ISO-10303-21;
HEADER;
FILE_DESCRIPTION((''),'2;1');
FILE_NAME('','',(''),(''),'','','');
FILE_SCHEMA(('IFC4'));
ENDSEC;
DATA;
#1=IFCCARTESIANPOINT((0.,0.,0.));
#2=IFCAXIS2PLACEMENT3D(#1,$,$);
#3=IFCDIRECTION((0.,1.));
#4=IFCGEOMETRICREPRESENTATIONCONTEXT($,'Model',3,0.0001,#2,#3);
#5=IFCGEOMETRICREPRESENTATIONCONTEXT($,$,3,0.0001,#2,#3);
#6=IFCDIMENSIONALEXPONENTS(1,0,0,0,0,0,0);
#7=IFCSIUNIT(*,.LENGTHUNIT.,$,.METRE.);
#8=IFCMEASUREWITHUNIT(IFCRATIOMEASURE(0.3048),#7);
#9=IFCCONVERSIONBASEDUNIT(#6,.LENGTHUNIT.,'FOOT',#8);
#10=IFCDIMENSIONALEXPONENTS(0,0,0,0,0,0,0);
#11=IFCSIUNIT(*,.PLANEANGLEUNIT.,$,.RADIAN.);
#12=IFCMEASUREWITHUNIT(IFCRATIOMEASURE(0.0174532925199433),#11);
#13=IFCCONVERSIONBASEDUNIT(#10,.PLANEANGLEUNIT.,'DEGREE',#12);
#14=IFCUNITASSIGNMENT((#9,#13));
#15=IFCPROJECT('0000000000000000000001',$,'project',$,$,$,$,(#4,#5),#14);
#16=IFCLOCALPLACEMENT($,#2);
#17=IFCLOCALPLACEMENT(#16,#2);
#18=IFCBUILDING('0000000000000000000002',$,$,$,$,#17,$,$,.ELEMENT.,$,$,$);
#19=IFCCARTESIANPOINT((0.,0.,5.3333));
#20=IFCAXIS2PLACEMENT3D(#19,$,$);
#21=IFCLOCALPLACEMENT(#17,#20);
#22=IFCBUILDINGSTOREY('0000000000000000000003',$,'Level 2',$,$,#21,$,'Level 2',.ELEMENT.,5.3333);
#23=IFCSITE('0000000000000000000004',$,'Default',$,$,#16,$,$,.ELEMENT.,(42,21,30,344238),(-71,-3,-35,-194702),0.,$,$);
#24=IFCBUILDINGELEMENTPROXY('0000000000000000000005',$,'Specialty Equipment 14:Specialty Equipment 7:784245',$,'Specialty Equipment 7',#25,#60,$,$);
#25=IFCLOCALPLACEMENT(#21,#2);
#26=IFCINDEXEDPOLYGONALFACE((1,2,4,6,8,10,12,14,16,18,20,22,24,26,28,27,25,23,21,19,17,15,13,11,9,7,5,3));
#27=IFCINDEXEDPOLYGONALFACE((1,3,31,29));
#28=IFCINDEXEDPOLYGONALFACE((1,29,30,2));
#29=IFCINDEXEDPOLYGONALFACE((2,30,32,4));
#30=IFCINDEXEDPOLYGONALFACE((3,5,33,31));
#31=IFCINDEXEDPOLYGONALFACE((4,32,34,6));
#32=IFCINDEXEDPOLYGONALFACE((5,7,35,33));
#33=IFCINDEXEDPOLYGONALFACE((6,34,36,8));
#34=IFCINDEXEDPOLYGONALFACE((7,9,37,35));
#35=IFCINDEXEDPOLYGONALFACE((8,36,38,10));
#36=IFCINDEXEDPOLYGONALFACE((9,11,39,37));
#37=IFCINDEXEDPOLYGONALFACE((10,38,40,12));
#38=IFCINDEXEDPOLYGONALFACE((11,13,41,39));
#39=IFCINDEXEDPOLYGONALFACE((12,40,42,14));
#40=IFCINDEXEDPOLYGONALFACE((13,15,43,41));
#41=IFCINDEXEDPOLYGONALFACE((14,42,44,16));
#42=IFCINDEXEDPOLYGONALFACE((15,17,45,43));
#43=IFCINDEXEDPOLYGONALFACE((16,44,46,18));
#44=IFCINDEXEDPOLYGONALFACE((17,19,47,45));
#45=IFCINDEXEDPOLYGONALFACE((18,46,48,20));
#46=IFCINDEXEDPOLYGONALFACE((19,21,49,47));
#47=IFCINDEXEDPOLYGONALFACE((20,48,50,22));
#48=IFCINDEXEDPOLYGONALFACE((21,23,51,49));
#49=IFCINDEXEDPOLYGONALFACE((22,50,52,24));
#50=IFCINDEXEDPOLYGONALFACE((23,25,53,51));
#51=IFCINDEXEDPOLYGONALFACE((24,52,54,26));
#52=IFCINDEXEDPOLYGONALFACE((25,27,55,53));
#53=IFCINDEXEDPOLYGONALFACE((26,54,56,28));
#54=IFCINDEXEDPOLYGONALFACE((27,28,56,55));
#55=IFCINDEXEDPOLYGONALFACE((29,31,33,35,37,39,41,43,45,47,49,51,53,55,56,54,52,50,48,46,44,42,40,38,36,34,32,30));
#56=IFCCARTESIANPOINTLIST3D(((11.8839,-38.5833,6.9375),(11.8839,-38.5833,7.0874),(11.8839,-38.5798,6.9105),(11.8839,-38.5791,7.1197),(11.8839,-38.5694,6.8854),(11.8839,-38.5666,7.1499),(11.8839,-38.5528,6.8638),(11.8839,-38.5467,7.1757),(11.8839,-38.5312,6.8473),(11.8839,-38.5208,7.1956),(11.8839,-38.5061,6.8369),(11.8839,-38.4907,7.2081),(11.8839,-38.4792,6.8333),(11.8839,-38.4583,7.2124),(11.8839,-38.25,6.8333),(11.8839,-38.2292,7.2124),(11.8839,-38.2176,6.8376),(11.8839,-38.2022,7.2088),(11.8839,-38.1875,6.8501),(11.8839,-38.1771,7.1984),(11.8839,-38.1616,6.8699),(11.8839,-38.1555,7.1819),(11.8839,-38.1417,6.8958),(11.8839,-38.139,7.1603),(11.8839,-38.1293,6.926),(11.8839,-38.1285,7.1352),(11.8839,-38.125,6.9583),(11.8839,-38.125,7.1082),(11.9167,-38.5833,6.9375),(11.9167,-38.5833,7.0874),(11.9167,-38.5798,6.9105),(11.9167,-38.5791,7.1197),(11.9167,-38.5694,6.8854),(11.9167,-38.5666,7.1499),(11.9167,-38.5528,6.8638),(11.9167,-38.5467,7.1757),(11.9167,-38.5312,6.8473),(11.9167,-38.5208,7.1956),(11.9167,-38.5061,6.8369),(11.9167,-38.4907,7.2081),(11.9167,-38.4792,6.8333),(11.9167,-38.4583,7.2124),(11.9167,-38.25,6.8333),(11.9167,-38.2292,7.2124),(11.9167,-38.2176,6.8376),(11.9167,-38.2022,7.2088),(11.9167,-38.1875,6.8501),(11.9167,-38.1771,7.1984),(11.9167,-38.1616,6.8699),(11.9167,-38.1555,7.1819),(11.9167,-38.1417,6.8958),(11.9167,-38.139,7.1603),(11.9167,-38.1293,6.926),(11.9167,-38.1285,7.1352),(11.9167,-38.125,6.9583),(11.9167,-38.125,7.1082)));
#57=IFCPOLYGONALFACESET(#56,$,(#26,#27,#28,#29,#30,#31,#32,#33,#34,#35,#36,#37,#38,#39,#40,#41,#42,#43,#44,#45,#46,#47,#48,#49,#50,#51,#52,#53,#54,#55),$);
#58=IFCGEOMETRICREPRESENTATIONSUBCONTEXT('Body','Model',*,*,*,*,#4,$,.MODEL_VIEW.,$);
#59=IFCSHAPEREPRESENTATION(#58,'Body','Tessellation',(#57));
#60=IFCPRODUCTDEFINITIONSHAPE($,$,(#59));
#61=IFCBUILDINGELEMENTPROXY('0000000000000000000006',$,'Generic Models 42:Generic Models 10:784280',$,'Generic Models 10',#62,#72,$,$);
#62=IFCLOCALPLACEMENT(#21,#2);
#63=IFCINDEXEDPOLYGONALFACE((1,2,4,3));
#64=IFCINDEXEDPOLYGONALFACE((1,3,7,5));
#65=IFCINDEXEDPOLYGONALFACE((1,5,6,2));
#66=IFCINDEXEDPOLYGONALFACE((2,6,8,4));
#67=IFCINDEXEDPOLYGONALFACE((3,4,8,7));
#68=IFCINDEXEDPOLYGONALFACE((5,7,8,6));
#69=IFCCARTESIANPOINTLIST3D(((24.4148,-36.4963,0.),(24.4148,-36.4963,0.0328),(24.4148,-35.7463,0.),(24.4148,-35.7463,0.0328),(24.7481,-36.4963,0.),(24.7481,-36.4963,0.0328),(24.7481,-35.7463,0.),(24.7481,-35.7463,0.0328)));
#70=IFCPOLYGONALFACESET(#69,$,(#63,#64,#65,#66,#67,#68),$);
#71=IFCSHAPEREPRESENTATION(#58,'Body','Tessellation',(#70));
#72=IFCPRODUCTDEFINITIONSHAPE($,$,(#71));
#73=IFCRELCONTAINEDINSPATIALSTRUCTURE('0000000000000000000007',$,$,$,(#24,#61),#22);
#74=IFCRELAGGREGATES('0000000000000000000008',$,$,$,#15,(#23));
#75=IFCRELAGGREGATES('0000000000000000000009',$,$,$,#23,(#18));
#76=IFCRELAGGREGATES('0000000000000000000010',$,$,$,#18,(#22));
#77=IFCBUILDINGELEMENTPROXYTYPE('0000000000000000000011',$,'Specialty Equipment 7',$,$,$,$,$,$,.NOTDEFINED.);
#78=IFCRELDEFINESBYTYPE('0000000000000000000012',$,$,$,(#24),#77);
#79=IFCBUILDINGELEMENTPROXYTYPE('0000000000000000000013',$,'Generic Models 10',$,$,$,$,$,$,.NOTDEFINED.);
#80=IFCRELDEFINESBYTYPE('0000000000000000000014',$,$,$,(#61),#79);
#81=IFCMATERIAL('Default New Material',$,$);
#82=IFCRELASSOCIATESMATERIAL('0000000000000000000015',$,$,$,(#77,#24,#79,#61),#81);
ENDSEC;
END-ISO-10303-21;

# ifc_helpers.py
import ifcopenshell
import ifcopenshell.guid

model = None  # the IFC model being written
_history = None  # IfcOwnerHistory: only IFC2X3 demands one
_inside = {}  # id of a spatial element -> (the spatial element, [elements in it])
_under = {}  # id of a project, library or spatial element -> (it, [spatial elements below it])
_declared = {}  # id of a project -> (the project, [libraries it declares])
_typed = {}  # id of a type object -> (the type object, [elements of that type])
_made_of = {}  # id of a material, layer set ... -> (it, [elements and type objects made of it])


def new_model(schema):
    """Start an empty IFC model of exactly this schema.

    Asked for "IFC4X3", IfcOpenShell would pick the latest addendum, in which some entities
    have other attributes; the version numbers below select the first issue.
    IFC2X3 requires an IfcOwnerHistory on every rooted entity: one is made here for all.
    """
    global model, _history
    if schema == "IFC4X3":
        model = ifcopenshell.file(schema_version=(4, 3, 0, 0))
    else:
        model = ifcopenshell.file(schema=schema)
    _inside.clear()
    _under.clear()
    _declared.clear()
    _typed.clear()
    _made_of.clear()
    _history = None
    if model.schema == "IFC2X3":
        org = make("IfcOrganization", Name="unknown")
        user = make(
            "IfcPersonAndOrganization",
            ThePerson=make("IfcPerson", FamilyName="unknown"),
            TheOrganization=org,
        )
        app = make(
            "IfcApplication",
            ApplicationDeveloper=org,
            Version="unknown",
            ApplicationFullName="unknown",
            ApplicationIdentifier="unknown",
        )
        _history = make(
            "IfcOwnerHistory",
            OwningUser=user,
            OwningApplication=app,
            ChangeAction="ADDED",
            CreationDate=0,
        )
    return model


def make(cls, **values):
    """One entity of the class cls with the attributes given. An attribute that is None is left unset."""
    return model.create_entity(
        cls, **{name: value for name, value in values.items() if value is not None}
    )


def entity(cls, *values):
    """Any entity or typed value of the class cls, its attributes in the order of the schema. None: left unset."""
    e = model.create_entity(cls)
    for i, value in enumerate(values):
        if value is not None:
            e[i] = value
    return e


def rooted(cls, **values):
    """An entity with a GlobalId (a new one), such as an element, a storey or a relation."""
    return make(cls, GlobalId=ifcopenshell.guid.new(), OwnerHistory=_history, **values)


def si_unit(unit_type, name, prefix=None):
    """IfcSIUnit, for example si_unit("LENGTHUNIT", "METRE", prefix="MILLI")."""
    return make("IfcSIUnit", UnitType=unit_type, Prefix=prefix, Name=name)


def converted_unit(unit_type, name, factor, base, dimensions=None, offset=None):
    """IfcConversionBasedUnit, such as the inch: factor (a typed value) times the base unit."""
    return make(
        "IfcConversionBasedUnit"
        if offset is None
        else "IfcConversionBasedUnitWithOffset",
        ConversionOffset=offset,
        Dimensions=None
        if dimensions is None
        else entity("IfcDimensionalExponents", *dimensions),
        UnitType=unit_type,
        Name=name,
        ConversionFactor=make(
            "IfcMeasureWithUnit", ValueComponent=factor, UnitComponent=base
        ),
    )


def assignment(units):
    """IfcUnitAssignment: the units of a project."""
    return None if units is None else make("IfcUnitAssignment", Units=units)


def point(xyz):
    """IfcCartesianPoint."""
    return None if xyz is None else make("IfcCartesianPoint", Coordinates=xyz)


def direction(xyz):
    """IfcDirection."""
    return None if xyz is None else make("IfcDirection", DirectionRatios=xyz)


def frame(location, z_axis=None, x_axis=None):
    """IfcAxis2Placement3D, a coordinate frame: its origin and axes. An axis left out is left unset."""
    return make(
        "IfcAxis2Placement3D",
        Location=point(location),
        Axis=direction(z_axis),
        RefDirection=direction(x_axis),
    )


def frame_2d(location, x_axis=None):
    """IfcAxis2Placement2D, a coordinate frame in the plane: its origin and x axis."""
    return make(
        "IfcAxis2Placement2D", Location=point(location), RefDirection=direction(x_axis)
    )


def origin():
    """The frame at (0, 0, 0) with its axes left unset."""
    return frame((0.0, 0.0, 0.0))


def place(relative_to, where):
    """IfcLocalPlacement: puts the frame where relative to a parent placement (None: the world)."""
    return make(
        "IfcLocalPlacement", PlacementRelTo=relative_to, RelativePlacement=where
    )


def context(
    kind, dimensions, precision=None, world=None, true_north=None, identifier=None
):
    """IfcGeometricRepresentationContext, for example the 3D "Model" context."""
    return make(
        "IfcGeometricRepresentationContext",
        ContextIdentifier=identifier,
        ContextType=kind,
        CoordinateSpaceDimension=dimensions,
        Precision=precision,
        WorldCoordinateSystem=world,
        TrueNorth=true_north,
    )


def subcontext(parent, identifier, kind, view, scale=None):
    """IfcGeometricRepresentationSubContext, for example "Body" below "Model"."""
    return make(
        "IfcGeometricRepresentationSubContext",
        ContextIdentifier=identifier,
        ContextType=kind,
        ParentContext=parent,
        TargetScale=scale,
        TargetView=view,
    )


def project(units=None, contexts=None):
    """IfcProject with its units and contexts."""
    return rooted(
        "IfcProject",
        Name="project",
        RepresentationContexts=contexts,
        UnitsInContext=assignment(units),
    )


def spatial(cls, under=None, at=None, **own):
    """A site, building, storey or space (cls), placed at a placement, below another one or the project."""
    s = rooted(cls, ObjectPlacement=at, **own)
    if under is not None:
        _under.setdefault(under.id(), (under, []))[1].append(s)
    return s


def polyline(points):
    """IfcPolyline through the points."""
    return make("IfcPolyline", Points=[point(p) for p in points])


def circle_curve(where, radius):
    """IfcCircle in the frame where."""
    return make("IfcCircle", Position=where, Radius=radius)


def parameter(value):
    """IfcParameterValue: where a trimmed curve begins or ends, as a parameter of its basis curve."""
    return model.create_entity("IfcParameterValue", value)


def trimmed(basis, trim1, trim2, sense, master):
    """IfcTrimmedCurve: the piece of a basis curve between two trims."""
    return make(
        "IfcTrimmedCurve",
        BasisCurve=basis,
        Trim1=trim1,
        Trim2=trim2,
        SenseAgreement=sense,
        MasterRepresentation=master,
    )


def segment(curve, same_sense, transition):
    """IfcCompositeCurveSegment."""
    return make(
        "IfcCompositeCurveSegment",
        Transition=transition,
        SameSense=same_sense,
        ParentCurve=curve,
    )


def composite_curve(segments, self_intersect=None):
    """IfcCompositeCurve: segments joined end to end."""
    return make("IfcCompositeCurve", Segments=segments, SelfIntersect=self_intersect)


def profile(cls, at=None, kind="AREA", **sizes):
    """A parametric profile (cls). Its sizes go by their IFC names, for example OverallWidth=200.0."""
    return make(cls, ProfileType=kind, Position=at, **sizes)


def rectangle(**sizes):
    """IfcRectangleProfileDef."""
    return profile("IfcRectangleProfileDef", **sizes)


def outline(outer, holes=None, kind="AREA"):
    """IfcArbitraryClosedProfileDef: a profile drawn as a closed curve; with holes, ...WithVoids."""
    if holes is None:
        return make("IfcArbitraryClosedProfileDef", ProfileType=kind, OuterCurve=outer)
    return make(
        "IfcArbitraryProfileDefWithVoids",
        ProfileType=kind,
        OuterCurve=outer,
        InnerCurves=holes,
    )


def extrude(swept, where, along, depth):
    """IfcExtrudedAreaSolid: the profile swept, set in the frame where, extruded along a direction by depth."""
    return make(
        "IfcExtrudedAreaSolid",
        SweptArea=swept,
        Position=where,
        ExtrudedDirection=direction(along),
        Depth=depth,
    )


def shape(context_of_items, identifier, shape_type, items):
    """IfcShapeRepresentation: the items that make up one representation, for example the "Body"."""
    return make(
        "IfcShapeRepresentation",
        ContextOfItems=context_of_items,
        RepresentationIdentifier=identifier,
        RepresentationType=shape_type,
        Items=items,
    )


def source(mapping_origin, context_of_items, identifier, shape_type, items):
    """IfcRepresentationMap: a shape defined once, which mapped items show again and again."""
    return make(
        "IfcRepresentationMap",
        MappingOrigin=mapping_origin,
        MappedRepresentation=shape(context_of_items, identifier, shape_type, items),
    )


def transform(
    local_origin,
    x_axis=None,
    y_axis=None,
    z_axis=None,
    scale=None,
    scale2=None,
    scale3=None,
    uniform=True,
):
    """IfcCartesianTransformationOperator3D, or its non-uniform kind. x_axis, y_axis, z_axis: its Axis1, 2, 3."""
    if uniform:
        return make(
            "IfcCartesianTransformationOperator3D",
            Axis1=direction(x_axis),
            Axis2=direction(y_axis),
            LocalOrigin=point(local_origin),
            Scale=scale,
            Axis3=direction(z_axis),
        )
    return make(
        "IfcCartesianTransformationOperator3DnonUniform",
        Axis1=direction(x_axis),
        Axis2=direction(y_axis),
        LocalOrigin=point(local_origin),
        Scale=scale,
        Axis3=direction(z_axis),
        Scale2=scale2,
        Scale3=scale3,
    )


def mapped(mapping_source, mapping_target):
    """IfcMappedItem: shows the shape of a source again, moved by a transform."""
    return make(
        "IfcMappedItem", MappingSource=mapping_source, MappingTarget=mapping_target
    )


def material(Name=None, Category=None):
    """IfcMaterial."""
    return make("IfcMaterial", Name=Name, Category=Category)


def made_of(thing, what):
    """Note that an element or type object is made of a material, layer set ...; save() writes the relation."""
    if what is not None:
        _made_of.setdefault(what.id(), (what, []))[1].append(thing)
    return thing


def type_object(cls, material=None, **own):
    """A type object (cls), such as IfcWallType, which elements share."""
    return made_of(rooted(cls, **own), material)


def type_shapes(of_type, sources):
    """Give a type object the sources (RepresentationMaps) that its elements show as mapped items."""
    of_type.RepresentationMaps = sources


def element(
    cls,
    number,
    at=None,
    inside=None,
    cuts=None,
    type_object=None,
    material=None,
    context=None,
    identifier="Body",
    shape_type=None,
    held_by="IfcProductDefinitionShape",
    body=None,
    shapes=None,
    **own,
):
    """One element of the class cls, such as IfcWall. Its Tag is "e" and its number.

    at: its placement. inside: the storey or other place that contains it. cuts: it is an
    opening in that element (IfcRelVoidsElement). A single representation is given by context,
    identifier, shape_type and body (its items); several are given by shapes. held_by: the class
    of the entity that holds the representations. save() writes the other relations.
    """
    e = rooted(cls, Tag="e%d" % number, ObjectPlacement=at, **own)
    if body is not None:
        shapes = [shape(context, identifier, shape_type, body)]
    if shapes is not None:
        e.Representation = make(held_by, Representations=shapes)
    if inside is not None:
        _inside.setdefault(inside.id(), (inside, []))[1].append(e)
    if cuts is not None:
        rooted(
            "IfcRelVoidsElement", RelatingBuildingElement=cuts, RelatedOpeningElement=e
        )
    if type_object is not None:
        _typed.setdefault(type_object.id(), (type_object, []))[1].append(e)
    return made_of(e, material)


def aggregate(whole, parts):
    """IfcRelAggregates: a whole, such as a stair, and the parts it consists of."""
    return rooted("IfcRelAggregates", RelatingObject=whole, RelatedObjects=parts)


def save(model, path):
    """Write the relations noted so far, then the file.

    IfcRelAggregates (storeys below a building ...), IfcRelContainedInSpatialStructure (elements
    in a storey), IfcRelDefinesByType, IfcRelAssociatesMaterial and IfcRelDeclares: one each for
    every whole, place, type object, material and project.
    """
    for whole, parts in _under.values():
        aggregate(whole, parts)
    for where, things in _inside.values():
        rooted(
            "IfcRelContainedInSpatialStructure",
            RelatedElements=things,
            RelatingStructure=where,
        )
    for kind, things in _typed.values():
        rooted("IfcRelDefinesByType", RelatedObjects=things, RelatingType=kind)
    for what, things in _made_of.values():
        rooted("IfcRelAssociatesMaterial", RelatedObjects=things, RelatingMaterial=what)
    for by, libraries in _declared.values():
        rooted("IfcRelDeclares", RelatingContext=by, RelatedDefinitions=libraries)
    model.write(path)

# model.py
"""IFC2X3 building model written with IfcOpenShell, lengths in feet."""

from ifc_helpers import new_model, entity, si_unit, converted_unit, direction, frame, frame_2d, origin, place, context, subcontext, project, spatial, polyline, circle_curve, parameter, trimmed, segment, composite_curve, rectangle, outline, extrude, source, transform, mapped, material, type_object, type_shapes, element, save


model = new_model("IFC2X3")

# Units and contexts
model_context = context("Model", 3, precision=0.0001, world=origin(), true_north=direction((0.0, 1.0)))
context_of_model = context(None, 3, precision=0.0001, world=origin(), true_north=direction((0.0, 1.0)))
body_context = subcontext(model_context, "Body", "Model", "MODEL_VIEW")
ifc_project = project(units=[converted_unit("LENGTHUNIT", "FOOT", entity("IfcRatioMeasure", 0.3048), si_unit("LENGTHUNIT", "METRE"), dimensions=[1, 0, 0, 0, 0, 0, 0]), converted_unit("PLANEANGLEUNIT", "DEGREE", entity("IfcRatioMeasure", 0.0174532925199433), si_unit("PLANEANGLEUNIT", "RADIAN"), dimensions=[0, 0, 0, 0, 0, 0, 0])], contexts=[model_context, context_of_model])

# Site, building, storey
site_placement = place(None, origin())
site = spatial("IfcSite", under=ifc_project, at=site_placement, Name="Default", CompositionType="ELEMENT", RefLatitude=(42, 21, 30, 344238), RefLongitude=(-71, -3, -35, -194702), RefElevation=0.0)
building_placement = place(site_placement, origin())
building = spatial("IfcBuilding", under=site, at=building_placement, CompositionType="ELEMENT")
storey_placement = place(building_placement, frame((0.0, 0.0, 5.3333)))
storey = spatial("IfcBuildingStorey", under=building, at=storey_placement, Name="Level 2", LongName="Level 2", CompositionType="ELEMENT", Elevation=5.3333)

# Shared definitions
ifc_material_1 = material(Name="Default New Material")

# Building element proxies
building_element_proxy_type_1 = type_object("IfcBuildingElementProxyType", Name="Specialty Equipment 7", PredefinedType="NOTDEFINED", material=ifc_material_1)
shared_shape_1 = source(origin(), body_context, "Body", "SweptSolid", [
    extrude(outline(composite_curve([segment(polyline([(-0.125, -0.1895), (0.1042, -0.1895)]), True, "CONTINUOUS"), segment(trimmed(circle_curve(frame_2d((0.1042, -0.0645), x_axis=(-1.0, 0.0)), 0.125), [parameter(90.0)], [parameter(180.0)], True, "PARAMETER"), True, "CONTINUOUS"), segment(polyline([(0.2292, -0.0645), (0.2292, 0.0853)]), True, "CONTINUOUS"), segment(trimmed(circle_curve(frame_2d((0.125, 0.0853), x_axis=(-1.0, 0.0)), 0.1042), [parameter(180.0)], [parameter(270.0)], True, "PARAMETER"), True, "CONTINUOUS"), segment(polyline([(0.125, 0.1895), (-0.1042, 0.1895)]), True, "CONTINUOUS"), segment(trimmed(circle_curve(frame_2d((-0.1042, 0.0645), x_axis=(-1.0, 0.0)), 0.125), [parameter(270.0)], [parameter(0.0)], True, "PARAMETER"), True, "CONTINUOUS"), segment(polyline([(-0.2292, 0.0645), (-0.2292, -0.0853)]), True, "CONTINUOUS"), segment(trimmed(circle_curve(frame_2d((-0.125, -0.0853), x_axis=(-1.0, 0.0)), 0.1042), [parameter(0.0)], [parameter(90.0)], True, "PARAMETER"), True, "CONTINUOUS")], self_intersect=False)), frame((0.0, 0.2344, 0.1947), z_axis=(1.0, 0.0, 0.0), x_axis=(0.0, 1.0, 0.0)), (0.0, 0.0, 1.0), 0.0328),
])
type_shapes(building_element_proxy_type_1, [shared_shape_1])
proxy_1_placement = place(storey_placement, frame((11.8839, -38.5886, 6.8281)))
element("IfcBuildingElementProxy", 1, at=proxy_1_placement, inside=storey, type_object=building_element_proxy_type_1, material=ifc_material_1, Name="Specialty Equipment 14:Specialty Equipment 7:784245", ObjectType="Specialty Equipment 7", context=body_context, shape_type="MappedRepresentation", body=[
    mapped(shared_shape_1, transform((0.0, 0.0, 0.0), scale=1.0)),
])
building_element_proxy_type_2 = type_object("IfcBuildingElementProxyType", Name="Generic Models 10", PredefinedType="NOTDEFINED", material=ifc_material_1)
shared_shape_2 = source(origin(), body_context, "Body", "SweptSolid", [
    extrude(rectangle(XDim=0.75, YDim=0.3333, at=frame_2d((0.0, 0.0), x_axis=(1.0, 0.0))), frame((0.1667, 0.375, 0.0), z_axis=(0.0, 0.0, 1.0), x_axis=(0.0, 1.0, 0.0)), (0.0, 0.0, 1.0), 0.0328),
])
type_shapes(building_element_proxy_type_2, [shared_shape_2])
proxy_2_placement = place(storey_placement, frame((24.4148, -36.4963, 0.0)))
element("IfcBuildingElementProxy", 2, at=proxy_2_placement, inside=storey, type_object=building_element_proxy_type_2, material=ifc_material_1, Name="Generic Models 42:Generic Models 10:784280", ObjectType="Generic Models 10", context=body_context, shape_type="MappedRepresentation", body=[
    mapped(shared_shape_2, transform((0.0, 0.0, 0.0), scale=1.0)),
])

save(model, "model.ifc")
